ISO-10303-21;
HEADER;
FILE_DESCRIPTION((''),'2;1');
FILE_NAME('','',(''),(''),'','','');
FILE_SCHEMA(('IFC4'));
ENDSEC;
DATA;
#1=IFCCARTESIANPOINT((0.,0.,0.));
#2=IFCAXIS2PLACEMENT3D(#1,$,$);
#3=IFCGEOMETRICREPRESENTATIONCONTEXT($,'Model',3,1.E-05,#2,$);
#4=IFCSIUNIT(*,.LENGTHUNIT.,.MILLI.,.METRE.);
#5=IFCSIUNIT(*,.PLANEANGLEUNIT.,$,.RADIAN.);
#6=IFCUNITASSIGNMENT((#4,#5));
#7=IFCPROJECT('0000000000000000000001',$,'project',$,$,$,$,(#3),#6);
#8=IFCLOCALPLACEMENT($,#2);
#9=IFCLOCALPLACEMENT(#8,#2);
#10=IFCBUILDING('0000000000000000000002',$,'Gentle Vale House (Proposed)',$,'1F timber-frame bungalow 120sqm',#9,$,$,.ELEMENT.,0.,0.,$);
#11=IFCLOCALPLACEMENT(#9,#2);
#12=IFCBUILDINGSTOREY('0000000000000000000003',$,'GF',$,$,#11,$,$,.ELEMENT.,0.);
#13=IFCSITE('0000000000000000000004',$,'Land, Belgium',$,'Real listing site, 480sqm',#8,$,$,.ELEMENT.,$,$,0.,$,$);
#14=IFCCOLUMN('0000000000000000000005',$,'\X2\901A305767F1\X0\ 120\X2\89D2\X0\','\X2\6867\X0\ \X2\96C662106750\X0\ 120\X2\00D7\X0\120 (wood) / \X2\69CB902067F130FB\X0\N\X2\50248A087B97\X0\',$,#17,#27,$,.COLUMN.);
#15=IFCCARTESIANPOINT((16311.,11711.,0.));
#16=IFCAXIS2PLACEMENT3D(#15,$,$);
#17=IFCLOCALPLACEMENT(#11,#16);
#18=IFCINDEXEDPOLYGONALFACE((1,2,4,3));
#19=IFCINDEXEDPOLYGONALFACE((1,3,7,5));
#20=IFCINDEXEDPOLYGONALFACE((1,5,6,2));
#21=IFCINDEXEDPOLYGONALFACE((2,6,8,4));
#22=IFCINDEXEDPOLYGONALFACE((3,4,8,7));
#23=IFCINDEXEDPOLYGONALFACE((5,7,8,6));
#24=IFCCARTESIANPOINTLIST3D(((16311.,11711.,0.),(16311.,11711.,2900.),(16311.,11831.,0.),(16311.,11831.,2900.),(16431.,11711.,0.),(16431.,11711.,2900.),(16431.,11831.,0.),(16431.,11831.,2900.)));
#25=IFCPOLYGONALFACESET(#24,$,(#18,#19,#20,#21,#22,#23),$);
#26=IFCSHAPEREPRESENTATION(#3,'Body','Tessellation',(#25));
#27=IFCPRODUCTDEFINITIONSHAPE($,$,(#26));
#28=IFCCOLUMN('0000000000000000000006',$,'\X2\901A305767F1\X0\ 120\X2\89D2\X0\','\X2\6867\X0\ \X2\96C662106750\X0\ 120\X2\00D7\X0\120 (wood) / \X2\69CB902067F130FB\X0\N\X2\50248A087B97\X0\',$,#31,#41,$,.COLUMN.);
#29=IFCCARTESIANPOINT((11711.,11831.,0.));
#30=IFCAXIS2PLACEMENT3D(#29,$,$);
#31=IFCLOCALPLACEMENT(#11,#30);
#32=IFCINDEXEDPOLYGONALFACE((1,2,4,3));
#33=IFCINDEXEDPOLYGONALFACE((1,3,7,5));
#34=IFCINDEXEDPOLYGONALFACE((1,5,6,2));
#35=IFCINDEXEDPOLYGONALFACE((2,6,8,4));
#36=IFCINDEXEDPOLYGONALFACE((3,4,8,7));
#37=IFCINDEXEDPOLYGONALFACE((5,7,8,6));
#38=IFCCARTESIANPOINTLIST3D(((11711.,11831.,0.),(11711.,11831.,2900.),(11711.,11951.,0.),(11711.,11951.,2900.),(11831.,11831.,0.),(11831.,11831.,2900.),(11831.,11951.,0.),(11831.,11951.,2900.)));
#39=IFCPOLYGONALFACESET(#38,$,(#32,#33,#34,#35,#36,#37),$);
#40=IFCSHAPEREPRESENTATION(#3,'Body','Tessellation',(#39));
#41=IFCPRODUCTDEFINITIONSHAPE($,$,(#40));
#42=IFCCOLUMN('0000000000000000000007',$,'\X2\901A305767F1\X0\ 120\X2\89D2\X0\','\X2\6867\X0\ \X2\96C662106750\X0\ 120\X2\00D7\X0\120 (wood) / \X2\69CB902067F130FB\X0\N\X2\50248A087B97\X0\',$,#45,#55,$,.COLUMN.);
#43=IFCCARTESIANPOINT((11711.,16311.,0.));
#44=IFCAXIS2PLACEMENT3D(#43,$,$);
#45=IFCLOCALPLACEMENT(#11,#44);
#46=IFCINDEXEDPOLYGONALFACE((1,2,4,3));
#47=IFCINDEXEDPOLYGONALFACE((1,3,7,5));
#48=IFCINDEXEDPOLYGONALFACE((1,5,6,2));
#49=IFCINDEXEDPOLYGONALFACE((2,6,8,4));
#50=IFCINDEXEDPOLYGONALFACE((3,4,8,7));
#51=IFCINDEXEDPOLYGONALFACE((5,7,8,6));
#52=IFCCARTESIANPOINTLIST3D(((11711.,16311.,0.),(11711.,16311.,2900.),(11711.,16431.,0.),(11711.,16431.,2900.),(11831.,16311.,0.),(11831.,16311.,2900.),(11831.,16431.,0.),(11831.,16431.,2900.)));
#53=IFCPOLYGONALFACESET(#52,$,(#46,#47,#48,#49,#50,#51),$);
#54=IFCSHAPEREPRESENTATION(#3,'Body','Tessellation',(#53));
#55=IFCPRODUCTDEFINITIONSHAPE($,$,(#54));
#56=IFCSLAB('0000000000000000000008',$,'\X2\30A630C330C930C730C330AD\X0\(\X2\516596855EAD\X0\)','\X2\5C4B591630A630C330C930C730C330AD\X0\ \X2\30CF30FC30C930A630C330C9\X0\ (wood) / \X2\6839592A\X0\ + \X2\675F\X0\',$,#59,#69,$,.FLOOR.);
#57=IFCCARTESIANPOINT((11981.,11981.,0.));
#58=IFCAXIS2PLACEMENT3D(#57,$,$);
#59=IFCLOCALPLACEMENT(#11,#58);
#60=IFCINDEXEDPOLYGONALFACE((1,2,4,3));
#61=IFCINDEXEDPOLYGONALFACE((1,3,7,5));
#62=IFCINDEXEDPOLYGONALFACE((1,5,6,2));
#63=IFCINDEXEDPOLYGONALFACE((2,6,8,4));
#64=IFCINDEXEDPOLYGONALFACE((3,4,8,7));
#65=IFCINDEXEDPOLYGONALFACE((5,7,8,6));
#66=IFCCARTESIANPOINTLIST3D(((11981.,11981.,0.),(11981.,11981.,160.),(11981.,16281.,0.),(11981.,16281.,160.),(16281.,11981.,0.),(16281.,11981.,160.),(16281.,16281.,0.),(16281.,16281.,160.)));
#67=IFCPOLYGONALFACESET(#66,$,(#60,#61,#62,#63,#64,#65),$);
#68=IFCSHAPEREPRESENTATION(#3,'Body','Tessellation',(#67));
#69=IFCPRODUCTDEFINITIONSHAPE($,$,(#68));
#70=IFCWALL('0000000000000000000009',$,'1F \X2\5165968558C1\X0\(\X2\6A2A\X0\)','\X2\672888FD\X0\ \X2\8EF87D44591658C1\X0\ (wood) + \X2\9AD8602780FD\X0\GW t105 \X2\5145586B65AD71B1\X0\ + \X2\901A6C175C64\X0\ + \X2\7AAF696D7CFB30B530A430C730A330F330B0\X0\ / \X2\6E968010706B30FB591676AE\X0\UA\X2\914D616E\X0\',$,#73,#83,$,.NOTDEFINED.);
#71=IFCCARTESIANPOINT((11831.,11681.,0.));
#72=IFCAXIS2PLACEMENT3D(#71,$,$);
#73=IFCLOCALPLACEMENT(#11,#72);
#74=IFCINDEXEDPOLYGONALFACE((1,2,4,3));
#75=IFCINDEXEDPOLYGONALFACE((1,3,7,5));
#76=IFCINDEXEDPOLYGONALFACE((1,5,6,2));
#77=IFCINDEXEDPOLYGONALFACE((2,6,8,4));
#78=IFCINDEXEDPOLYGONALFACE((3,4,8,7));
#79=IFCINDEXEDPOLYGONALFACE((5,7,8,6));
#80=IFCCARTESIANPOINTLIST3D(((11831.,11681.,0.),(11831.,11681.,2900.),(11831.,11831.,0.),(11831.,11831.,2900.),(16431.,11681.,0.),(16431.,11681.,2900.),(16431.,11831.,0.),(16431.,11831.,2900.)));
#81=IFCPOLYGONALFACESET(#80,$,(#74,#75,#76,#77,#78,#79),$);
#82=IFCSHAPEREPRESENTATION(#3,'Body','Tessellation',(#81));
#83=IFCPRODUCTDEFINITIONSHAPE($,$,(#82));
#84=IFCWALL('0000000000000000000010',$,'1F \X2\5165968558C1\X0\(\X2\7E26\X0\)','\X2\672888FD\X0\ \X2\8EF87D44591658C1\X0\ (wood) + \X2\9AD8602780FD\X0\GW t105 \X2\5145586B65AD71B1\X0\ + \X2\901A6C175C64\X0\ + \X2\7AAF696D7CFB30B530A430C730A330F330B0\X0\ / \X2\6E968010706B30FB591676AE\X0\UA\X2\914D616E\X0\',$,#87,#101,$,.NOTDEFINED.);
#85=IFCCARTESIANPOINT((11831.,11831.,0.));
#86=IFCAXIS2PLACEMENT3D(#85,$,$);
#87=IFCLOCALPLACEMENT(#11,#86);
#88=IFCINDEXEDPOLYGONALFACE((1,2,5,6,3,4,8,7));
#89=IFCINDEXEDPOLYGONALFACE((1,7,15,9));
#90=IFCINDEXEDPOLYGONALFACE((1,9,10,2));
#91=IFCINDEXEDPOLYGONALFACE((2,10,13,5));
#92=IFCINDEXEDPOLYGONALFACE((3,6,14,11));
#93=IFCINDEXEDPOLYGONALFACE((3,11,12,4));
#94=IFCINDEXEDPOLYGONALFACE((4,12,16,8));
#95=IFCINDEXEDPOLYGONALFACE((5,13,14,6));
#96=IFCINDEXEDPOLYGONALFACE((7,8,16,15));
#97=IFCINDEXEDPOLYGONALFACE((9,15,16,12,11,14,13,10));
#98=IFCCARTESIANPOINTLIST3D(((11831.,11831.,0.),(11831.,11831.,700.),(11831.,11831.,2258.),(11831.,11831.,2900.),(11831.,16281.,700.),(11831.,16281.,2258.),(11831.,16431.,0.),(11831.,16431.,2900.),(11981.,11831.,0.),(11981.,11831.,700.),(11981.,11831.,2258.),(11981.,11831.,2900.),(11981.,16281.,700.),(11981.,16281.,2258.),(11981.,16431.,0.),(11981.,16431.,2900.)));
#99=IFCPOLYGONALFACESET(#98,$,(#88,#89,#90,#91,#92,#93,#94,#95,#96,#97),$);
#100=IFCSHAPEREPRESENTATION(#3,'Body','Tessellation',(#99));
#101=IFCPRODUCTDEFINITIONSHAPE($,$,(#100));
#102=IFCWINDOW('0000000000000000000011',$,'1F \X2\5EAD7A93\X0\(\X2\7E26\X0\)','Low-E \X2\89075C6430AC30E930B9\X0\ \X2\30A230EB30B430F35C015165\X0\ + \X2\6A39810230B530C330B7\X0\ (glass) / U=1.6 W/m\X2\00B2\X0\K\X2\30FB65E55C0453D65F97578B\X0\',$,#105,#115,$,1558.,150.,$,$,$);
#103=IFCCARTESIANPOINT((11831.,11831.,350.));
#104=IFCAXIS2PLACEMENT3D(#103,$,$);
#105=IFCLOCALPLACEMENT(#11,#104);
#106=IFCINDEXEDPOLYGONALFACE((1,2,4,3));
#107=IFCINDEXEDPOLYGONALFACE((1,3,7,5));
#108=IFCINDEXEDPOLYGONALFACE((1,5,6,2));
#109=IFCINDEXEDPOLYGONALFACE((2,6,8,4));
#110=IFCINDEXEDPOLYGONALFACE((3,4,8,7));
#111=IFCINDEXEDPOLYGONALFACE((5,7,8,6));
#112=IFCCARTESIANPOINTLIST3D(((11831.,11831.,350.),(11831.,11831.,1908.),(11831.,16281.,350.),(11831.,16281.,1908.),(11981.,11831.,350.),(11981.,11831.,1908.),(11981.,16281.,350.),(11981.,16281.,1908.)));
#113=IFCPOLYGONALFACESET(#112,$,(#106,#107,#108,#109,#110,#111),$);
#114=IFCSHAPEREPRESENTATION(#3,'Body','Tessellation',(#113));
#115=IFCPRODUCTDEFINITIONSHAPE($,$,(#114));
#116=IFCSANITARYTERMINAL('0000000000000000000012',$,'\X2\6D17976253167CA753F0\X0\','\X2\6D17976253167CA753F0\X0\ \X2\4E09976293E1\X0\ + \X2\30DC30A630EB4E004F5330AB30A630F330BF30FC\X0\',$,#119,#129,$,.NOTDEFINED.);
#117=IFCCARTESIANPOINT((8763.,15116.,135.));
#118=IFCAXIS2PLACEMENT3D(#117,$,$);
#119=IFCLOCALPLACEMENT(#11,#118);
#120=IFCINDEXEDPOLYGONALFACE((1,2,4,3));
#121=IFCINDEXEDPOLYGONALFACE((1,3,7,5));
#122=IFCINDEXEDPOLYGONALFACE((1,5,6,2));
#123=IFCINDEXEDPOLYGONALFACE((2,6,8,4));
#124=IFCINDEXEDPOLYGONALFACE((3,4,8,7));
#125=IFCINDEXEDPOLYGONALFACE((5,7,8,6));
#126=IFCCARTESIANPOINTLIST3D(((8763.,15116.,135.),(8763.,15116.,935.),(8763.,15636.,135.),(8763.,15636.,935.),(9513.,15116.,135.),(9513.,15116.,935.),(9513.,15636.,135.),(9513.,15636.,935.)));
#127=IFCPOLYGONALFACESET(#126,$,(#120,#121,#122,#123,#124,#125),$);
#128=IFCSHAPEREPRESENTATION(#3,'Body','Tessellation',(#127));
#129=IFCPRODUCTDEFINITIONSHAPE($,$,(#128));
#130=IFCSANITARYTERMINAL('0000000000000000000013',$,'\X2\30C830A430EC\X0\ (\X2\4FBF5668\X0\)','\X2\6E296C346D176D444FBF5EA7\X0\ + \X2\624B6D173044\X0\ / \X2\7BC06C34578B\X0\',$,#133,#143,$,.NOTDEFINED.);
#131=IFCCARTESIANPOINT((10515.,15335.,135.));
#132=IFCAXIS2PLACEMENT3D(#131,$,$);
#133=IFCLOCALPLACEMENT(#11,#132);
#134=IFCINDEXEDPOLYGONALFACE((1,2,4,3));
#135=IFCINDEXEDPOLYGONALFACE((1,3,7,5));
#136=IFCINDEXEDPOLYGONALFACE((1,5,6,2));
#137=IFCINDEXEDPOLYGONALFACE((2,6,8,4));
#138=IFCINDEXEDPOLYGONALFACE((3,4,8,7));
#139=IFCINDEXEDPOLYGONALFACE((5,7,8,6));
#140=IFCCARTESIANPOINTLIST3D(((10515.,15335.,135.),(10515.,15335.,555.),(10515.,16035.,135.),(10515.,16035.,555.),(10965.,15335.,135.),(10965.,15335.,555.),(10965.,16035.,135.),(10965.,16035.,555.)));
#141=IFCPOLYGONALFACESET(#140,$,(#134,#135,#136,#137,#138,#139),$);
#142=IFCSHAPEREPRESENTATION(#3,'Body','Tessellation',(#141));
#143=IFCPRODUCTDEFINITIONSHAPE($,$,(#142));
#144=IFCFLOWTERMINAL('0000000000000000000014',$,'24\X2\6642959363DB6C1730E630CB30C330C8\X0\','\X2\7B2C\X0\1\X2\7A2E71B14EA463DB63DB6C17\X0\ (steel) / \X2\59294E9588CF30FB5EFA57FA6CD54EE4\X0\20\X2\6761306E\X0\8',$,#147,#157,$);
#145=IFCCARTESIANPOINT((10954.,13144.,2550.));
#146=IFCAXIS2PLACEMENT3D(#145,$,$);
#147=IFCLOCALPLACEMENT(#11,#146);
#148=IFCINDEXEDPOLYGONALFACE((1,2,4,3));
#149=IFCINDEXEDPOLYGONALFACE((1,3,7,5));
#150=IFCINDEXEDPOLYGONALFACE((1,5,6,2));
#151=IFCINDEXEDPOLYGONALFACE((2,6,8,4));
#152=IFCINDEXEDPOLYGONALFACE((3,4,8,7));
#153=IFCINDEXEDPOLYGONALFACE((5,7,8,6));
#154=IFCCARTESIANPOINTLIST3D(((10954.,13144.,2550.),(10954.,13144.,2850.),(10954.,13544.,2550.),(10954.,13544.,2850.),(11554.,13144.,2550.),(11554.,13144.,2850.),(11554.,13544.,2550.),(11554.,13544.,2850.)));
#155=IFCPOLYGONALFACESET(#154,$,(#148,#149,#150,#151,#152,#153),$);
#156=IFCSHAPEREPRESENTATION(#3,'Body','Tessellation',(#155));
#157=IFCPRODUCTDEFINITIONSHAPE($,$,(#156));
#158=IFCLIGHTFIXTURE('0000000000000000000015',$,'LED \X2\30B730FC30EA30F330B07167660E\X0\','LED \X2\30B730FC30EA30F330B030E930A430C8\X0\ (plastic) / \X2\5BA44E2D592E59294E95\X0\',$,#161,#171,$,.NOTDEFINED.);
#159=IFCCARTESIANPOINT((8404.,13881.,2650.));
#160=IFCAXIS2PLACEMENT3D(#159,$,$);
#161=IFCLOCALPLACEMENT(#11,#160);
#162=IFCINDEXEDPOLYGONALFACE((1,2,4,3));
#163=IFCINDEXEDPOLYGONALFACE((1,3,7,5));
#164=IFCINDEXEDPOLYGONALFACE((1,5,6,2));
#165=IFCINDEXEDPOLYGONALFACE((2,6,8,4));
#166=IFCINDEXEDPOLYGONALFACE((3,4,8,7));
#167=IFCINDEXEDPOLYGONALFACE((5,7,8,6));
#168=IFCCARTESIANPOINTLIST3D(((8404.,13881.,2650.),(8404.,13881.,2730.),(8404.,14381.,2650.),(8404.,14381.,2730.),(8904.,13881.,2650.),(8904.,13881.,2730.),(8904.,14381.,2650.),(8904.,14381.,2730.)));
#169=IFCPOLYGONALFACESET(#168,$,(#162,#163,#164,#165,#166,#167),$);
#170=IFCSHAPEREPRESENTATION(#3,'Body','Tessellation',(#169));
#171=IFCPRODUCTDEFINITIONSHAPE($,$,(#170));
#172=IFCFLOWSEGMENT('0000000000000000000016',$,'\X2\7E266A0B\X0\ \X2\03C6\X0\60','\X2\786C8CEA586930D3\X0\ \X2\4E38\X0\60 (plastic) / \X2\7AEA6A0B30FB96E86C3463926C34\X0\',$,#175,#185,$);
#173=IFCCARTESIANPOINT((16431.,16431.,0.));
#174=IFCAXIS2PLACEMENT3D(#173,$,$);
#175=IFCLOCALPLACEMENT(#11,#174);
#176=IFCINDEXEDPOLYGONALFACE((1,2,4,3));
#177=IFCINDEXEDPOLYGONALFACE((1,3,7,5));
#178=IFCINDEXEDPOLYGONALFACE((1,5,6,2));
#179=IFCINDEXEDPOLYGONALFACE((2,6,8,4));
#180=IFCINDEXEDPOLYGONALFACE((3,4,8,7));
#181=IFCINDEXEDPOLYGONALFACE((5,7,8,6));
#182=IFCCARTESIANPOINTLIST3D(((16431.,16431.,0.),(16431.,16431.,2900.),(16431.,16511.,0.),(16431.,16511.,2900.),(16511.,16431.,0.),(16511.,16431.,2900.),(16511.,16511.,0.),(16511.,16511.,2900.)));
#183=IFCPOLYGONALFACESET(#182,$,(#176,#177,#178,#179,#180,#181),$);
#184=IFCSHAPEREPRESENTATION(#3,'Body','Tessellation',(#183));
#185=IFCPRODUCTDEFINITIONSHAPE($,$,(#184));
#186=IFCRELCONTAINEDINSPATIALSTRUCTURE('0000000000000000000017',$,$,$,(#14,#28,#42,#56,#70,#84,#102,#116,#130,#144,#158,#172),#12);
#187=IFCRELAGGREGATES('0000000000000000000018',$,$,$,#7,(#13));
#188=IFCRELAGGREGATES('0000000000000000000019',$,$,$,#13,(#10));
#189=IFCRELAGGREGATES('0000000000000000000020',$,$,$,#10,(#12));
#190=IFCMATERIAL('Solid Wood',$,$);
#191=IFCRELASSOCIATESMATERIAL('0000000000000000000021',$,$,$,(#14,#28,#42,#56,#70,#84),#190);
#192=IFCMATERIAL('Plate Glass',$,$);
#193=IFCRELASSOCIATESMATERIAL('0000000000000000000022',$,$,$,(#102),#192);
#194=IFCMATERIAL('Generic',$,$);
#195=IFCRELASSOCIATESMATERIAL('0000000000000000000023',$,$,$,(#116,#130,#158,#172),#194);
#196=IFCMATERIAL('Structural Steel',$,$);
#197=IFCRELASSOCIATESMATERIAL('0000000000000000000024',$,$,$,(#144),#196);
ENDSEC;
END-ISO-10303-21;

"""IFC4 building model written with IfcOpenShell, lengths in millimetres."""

from ifc_helpers import new_model, si_unit, frame, frame_2d, origin, place, context, project, spatial, rectangle, extrude, material, element, fill, save


model = new_model("IFC4")

# Units and contexts
model_context = context("Model", 3, precision=1e-05, world=origin())
ifc_project = project(units=[si_unit("LENGTHUNIT", "METRE", prefix="MILLI"), si_unit("PLANEANGLEUNIT", "RADIAN")], contexts=[model_context])

# Site, building, storey
site_placement = place(None, origin())
site = spatial("IfcSite", under=ifc_project, at=site_placement, Name="Land, Belgium", ObjectType="Real listing site, 480sqm", CompositionType="ELEMENT", RefElevation=0.0)
building_placement = place(site_placement, origin())
building = spatial("IfcBuilding", under=site, at=building_placement, Name="Gentle Vale House (Proposed)", ObjectType="1F timber-frame bungalow 120sqm", CompositionType="ELEMENT", ElevationOfRefHeight=0.0, ElevationOfTerrain=0.0)
storey_placement = place(building_placement, origin())
storey = spatial("IfcBuildingStorey", under=building, at=storey_placement, Name="GF", CompositionType="ELEMENT", Elevation=0.0)

# Columns
ifc_material_1 = material(Name="Solid Wood")
column_1_placement = place(storey_placement, frame((16311.0, 11711.0, 0.0)))
element("IfcColumn", 1, at=column_1_placement, inside=storey, material=ifc_material_1, Name="通し柱 120角", Description="桧 集成材 120×120 (wood) / 構造柱・N値計算", PredefinedType="COLUMN", context=model_context, shape_type="SweptSolid", body=[
    extrude(rectangle(XDim=120.0, YDim=120.0, at=frame_2d((60.0, 60.0))), frame((16311.0, 11711.0, 0.0)), (0.0, 0.0, 1.0), 2900.0),
])
column_2_placement = place(storey_placement, frame((11711.0, 11831.0, 0.0)))
element("IfcColumn", 2, at=column_2_placement, inside=storey, material=ifc_material_1, Name="通し柱 120角", Description="桧 集成材 120×120 (wood) / 構造柱・N値計算", PredefinedType="COLUMN", context=model_context, shape_type="SweptSolid", body=[
    extrude(rectangle(XDim=120.0, YDim=120.0, at=frame_2d((60.0, 60.0))), frame((11711.0, 11831.0, 0.0)), (0.0, 0.0, 1.0), 2900.0),
])
column_3_placement = place(storey_placement, frame((11711.0, 16311.0, 0.0)))
element("IfcColumn", 3, at=column_3_placement, inside=storey, material=ifc_material_1, Name="通し柱 120角", Description="桧 集成材 120×120 (wood) / 構造柱・N値計算", PredefinedType="COLUMN", context=model_context, shape_type="SweptSolid", body=[
    extrude(rectangle(XDim=120.0, YDim=120.0, at=frame_2d((60.0, 60.0))), frame((11711.0, 16311.0, 0.0)), (0.0, 0.0, 1.0), 2900.0),
])

# Slab
slab_placement = place(storey_placement, frame((11981.0, 11981.0, 0.0)))
element("IfcSlab", 4, at=slab_placement, inside=storey, material=ifc_material_1, Name="ウッドデッキ(入隅庭)", Description="屋外ウッドデッキ ハードウッド (wood) / 根太 + 束", PredefinedType="FLOOR", context=model_context, shape_type="SweptSolid", body=[
    extrude(rectangle(XDim=4300.0, YDim=4300.0, at=frame_2d((2150.0, 2150.0))), frame((11981.0, 11981.0, 0.0)), (0.0, 0.0, 1.0), 160.0),
])

# Wall
wall_1_placement = place(storey_placement, frame((11831.0, 11681.0, 0.0)))
element("IfcWall", 5, at=wall_1_placement, inside=storey, material=ifc_material_1, Name="1F 入隅壁(横)", Description="木製 軸組外壁 (wood) + 高性能GW t105 充填断熱 + 通気層 + 窯業系サイディング / 準耐火・外皮UA配慮", PredefinedType="NOTDEFINED", context=model_context, shape_type="SweptSolid", body=[
    extrude(rectangle(XDim=4600.0, YDim=150.0, at=frame_2d((2300.0, 75.0))), frame((11831.0, 11681.0, 0.0)), (0.0, 0.0, 1.0), 2900.0),
])

# Wall, opening, window
wall_2_placement = place(storey_placement, frame((11831.0, 11831.0, 0.0)))
wall_2 = element("IfcWall", 6, at=wall_2_placement, inside=storey, material=ifc_material_1, Name="1F 入隅壁(縦)", Description="木製 軸組外壁 (wood) + 高性能GW t105 充填断熱 + 通気層 + 窯業系サイディング / 準耐火・外皮UA配慮", PredefinedType="NOTDEFINED", context=model_context, shape_type="SweptSolid", body=[
    extrude(rectangle(XDim=150.0, YDim=4600.0, at=frame_2d((75.0, 2300.0))), frame((11831.0, 11831.0, 0.0)), (0.0, 0.0, 1.0), 2900.0),
])
opening_placement = place(storey_placement, frame((11831.0, 11831.0, 350.0)))
opening = element("IfcOpeningElement", 7, at=opening_placement, cuts=wall_2, PredefinedType="NOTDEFINED", context=model_context, shape_type="SweptSolid", body=[
    extrude(rectangle(XDim=150.0, YDim=4450.0, at=frame_2d((75.0, 2225.0))), frame((11831.0, 11831.0, 350.0)), (0.0, 0.0, 1.0), 1558.0),
])
ifc_material_2 = material(Name="Plate Glass")
window_placement = place(storey_placement, frame((11831.0, 11831.0, 350.0)))
window = element("IfcWindow", 8, at=window_placement, inside=storey, material=ifc_material_2, Name="1F 庭窓(縦)", Description="Low-E 複層ガラス アルゴン封入 + 樹脂サッシ (glass) / U=1.6 W/m²K・日射取得型", OverallHeight=1558.0, OverallWidth=150.0, context=model_context, shape_type="SweptSolid", body=[
    extrude(rectangle(XDim=150.0, YDim=4450.0, at=frame_2d((75.0, 2225.0))), frame((11831.0, 11831.0, 350.0)), (0.0, 0.0, 1.0), 1558.0),
])
fill(opening, window)

# Sanitary terminals
ifc_material_3 = material(Name="Generic")
sanitary_terminal_1_placement = place(storey_placement, frame((8763.0, 15116.0, 135.0)))
element("IfcSanitaryTerminal", 9, at=sanitary_terminal_1_placement, inside=storey, material=ifc_material_3, Name="洗面化粧台", Description="洗面化粧台 三面鏡 + ボウル一体カウンター", PredefinedType="NOTDEFINED", context=model_context, shape_type="SweptSolid", body=[
    extrude(rectangle(XDim=750.0, YDim=520.0, at=frame_2d((375.0, 260.0))), frame((8763.0, 15116.0, 135.0)), (0.0, 0.0, 1.0), 800.0),
])
sanitary_terminal_2_placement = place(storey_placement, frame((10515.0, 15335.0, 135.0)))
element("IfcSanitaryTerminal", 10, at=sanitary_terminal_2_placement, inside=storey, material=ifc_material_3, Name="トイレ (便器)", Description="温水洗浄便座 + 手洗い / 節水型", PredefinedType="NOTDEFINED", context=model_context, shape_type="SweptSolid", body=[
    extrude(rectangle(XDim=450.0, YDim=700.0, at=frame_2d((225.0, 350.0))), frame((10515.0, 15335.0, 135.0)), (0.0, 0.0, 1.0), 420.0),
])

# Flow terminal
ifc_material_4 = material(Name="Structural Steel")
flow_terminal_placement = place(storey_placement, frame((10954.0, 13144.0, 2550.0)))
element("IfcFlowTerminal", 11, at=flow_terminal_placement, inside=storey, material=ifc_material_4, Name="24時間換気ユニット", Description="第1種熱交換換気 (steel) / 天井裏・建基法令20条の8", context=model_context, shape_type="SweptSolid", body=[
    extrude(rectangle(XDim=600.0, YDim=400.0, at=frame_2d((300.0, 200.0))), frame((10954.0, 13144.0, 2550.0)), (0.0, 0.0, 1.0), 300.0),
])

# Light fixture
light_fixture_placement = place(storey_placement, frame((8404.0, 13881.0, 2650.0)))
element("IfcLightFixture", 12, at=light_fixture_placement, inside=storey, material=ifc_material_3, Name="LED シーリング照明", Description="LED シーリングライト (plastic) / 室中央天井", PredefinedType="NOTDEFINED", context=model_context, shape_type="SweptSolid", body=[
    extrude(rectangle(XDim=500.0, YDim=500.0, at=frame_2d((250.0, 250.0))), frame((8404.0, 13881.0, 2650.0)), (0.0, 0.0, 1.0), 80.0),
])

# Flow segment
flow_segment_placement = place(storey_placement, frame((16431.0, 16431.0, 0.0)))
element("IfcFlowSegment", 13, at=flow_segment_placement, inside=storey, material=ifc_material_3, Name="縦樋 φ60", Description="硬質塩ビ 丸60 (plastic) / 竪樋・雨水排水", context=model_context, shape_type="SweptSolid", body=[
    extrude(rectangle(XDim=80.0, YDim=80.0, at=frame_2d((40.0, 40.0))), frame((16431.0, 16431.0, 0.0)), (0.0, 0.0, 1.0), 2900.0),
])

save(model, "model.ifc")
